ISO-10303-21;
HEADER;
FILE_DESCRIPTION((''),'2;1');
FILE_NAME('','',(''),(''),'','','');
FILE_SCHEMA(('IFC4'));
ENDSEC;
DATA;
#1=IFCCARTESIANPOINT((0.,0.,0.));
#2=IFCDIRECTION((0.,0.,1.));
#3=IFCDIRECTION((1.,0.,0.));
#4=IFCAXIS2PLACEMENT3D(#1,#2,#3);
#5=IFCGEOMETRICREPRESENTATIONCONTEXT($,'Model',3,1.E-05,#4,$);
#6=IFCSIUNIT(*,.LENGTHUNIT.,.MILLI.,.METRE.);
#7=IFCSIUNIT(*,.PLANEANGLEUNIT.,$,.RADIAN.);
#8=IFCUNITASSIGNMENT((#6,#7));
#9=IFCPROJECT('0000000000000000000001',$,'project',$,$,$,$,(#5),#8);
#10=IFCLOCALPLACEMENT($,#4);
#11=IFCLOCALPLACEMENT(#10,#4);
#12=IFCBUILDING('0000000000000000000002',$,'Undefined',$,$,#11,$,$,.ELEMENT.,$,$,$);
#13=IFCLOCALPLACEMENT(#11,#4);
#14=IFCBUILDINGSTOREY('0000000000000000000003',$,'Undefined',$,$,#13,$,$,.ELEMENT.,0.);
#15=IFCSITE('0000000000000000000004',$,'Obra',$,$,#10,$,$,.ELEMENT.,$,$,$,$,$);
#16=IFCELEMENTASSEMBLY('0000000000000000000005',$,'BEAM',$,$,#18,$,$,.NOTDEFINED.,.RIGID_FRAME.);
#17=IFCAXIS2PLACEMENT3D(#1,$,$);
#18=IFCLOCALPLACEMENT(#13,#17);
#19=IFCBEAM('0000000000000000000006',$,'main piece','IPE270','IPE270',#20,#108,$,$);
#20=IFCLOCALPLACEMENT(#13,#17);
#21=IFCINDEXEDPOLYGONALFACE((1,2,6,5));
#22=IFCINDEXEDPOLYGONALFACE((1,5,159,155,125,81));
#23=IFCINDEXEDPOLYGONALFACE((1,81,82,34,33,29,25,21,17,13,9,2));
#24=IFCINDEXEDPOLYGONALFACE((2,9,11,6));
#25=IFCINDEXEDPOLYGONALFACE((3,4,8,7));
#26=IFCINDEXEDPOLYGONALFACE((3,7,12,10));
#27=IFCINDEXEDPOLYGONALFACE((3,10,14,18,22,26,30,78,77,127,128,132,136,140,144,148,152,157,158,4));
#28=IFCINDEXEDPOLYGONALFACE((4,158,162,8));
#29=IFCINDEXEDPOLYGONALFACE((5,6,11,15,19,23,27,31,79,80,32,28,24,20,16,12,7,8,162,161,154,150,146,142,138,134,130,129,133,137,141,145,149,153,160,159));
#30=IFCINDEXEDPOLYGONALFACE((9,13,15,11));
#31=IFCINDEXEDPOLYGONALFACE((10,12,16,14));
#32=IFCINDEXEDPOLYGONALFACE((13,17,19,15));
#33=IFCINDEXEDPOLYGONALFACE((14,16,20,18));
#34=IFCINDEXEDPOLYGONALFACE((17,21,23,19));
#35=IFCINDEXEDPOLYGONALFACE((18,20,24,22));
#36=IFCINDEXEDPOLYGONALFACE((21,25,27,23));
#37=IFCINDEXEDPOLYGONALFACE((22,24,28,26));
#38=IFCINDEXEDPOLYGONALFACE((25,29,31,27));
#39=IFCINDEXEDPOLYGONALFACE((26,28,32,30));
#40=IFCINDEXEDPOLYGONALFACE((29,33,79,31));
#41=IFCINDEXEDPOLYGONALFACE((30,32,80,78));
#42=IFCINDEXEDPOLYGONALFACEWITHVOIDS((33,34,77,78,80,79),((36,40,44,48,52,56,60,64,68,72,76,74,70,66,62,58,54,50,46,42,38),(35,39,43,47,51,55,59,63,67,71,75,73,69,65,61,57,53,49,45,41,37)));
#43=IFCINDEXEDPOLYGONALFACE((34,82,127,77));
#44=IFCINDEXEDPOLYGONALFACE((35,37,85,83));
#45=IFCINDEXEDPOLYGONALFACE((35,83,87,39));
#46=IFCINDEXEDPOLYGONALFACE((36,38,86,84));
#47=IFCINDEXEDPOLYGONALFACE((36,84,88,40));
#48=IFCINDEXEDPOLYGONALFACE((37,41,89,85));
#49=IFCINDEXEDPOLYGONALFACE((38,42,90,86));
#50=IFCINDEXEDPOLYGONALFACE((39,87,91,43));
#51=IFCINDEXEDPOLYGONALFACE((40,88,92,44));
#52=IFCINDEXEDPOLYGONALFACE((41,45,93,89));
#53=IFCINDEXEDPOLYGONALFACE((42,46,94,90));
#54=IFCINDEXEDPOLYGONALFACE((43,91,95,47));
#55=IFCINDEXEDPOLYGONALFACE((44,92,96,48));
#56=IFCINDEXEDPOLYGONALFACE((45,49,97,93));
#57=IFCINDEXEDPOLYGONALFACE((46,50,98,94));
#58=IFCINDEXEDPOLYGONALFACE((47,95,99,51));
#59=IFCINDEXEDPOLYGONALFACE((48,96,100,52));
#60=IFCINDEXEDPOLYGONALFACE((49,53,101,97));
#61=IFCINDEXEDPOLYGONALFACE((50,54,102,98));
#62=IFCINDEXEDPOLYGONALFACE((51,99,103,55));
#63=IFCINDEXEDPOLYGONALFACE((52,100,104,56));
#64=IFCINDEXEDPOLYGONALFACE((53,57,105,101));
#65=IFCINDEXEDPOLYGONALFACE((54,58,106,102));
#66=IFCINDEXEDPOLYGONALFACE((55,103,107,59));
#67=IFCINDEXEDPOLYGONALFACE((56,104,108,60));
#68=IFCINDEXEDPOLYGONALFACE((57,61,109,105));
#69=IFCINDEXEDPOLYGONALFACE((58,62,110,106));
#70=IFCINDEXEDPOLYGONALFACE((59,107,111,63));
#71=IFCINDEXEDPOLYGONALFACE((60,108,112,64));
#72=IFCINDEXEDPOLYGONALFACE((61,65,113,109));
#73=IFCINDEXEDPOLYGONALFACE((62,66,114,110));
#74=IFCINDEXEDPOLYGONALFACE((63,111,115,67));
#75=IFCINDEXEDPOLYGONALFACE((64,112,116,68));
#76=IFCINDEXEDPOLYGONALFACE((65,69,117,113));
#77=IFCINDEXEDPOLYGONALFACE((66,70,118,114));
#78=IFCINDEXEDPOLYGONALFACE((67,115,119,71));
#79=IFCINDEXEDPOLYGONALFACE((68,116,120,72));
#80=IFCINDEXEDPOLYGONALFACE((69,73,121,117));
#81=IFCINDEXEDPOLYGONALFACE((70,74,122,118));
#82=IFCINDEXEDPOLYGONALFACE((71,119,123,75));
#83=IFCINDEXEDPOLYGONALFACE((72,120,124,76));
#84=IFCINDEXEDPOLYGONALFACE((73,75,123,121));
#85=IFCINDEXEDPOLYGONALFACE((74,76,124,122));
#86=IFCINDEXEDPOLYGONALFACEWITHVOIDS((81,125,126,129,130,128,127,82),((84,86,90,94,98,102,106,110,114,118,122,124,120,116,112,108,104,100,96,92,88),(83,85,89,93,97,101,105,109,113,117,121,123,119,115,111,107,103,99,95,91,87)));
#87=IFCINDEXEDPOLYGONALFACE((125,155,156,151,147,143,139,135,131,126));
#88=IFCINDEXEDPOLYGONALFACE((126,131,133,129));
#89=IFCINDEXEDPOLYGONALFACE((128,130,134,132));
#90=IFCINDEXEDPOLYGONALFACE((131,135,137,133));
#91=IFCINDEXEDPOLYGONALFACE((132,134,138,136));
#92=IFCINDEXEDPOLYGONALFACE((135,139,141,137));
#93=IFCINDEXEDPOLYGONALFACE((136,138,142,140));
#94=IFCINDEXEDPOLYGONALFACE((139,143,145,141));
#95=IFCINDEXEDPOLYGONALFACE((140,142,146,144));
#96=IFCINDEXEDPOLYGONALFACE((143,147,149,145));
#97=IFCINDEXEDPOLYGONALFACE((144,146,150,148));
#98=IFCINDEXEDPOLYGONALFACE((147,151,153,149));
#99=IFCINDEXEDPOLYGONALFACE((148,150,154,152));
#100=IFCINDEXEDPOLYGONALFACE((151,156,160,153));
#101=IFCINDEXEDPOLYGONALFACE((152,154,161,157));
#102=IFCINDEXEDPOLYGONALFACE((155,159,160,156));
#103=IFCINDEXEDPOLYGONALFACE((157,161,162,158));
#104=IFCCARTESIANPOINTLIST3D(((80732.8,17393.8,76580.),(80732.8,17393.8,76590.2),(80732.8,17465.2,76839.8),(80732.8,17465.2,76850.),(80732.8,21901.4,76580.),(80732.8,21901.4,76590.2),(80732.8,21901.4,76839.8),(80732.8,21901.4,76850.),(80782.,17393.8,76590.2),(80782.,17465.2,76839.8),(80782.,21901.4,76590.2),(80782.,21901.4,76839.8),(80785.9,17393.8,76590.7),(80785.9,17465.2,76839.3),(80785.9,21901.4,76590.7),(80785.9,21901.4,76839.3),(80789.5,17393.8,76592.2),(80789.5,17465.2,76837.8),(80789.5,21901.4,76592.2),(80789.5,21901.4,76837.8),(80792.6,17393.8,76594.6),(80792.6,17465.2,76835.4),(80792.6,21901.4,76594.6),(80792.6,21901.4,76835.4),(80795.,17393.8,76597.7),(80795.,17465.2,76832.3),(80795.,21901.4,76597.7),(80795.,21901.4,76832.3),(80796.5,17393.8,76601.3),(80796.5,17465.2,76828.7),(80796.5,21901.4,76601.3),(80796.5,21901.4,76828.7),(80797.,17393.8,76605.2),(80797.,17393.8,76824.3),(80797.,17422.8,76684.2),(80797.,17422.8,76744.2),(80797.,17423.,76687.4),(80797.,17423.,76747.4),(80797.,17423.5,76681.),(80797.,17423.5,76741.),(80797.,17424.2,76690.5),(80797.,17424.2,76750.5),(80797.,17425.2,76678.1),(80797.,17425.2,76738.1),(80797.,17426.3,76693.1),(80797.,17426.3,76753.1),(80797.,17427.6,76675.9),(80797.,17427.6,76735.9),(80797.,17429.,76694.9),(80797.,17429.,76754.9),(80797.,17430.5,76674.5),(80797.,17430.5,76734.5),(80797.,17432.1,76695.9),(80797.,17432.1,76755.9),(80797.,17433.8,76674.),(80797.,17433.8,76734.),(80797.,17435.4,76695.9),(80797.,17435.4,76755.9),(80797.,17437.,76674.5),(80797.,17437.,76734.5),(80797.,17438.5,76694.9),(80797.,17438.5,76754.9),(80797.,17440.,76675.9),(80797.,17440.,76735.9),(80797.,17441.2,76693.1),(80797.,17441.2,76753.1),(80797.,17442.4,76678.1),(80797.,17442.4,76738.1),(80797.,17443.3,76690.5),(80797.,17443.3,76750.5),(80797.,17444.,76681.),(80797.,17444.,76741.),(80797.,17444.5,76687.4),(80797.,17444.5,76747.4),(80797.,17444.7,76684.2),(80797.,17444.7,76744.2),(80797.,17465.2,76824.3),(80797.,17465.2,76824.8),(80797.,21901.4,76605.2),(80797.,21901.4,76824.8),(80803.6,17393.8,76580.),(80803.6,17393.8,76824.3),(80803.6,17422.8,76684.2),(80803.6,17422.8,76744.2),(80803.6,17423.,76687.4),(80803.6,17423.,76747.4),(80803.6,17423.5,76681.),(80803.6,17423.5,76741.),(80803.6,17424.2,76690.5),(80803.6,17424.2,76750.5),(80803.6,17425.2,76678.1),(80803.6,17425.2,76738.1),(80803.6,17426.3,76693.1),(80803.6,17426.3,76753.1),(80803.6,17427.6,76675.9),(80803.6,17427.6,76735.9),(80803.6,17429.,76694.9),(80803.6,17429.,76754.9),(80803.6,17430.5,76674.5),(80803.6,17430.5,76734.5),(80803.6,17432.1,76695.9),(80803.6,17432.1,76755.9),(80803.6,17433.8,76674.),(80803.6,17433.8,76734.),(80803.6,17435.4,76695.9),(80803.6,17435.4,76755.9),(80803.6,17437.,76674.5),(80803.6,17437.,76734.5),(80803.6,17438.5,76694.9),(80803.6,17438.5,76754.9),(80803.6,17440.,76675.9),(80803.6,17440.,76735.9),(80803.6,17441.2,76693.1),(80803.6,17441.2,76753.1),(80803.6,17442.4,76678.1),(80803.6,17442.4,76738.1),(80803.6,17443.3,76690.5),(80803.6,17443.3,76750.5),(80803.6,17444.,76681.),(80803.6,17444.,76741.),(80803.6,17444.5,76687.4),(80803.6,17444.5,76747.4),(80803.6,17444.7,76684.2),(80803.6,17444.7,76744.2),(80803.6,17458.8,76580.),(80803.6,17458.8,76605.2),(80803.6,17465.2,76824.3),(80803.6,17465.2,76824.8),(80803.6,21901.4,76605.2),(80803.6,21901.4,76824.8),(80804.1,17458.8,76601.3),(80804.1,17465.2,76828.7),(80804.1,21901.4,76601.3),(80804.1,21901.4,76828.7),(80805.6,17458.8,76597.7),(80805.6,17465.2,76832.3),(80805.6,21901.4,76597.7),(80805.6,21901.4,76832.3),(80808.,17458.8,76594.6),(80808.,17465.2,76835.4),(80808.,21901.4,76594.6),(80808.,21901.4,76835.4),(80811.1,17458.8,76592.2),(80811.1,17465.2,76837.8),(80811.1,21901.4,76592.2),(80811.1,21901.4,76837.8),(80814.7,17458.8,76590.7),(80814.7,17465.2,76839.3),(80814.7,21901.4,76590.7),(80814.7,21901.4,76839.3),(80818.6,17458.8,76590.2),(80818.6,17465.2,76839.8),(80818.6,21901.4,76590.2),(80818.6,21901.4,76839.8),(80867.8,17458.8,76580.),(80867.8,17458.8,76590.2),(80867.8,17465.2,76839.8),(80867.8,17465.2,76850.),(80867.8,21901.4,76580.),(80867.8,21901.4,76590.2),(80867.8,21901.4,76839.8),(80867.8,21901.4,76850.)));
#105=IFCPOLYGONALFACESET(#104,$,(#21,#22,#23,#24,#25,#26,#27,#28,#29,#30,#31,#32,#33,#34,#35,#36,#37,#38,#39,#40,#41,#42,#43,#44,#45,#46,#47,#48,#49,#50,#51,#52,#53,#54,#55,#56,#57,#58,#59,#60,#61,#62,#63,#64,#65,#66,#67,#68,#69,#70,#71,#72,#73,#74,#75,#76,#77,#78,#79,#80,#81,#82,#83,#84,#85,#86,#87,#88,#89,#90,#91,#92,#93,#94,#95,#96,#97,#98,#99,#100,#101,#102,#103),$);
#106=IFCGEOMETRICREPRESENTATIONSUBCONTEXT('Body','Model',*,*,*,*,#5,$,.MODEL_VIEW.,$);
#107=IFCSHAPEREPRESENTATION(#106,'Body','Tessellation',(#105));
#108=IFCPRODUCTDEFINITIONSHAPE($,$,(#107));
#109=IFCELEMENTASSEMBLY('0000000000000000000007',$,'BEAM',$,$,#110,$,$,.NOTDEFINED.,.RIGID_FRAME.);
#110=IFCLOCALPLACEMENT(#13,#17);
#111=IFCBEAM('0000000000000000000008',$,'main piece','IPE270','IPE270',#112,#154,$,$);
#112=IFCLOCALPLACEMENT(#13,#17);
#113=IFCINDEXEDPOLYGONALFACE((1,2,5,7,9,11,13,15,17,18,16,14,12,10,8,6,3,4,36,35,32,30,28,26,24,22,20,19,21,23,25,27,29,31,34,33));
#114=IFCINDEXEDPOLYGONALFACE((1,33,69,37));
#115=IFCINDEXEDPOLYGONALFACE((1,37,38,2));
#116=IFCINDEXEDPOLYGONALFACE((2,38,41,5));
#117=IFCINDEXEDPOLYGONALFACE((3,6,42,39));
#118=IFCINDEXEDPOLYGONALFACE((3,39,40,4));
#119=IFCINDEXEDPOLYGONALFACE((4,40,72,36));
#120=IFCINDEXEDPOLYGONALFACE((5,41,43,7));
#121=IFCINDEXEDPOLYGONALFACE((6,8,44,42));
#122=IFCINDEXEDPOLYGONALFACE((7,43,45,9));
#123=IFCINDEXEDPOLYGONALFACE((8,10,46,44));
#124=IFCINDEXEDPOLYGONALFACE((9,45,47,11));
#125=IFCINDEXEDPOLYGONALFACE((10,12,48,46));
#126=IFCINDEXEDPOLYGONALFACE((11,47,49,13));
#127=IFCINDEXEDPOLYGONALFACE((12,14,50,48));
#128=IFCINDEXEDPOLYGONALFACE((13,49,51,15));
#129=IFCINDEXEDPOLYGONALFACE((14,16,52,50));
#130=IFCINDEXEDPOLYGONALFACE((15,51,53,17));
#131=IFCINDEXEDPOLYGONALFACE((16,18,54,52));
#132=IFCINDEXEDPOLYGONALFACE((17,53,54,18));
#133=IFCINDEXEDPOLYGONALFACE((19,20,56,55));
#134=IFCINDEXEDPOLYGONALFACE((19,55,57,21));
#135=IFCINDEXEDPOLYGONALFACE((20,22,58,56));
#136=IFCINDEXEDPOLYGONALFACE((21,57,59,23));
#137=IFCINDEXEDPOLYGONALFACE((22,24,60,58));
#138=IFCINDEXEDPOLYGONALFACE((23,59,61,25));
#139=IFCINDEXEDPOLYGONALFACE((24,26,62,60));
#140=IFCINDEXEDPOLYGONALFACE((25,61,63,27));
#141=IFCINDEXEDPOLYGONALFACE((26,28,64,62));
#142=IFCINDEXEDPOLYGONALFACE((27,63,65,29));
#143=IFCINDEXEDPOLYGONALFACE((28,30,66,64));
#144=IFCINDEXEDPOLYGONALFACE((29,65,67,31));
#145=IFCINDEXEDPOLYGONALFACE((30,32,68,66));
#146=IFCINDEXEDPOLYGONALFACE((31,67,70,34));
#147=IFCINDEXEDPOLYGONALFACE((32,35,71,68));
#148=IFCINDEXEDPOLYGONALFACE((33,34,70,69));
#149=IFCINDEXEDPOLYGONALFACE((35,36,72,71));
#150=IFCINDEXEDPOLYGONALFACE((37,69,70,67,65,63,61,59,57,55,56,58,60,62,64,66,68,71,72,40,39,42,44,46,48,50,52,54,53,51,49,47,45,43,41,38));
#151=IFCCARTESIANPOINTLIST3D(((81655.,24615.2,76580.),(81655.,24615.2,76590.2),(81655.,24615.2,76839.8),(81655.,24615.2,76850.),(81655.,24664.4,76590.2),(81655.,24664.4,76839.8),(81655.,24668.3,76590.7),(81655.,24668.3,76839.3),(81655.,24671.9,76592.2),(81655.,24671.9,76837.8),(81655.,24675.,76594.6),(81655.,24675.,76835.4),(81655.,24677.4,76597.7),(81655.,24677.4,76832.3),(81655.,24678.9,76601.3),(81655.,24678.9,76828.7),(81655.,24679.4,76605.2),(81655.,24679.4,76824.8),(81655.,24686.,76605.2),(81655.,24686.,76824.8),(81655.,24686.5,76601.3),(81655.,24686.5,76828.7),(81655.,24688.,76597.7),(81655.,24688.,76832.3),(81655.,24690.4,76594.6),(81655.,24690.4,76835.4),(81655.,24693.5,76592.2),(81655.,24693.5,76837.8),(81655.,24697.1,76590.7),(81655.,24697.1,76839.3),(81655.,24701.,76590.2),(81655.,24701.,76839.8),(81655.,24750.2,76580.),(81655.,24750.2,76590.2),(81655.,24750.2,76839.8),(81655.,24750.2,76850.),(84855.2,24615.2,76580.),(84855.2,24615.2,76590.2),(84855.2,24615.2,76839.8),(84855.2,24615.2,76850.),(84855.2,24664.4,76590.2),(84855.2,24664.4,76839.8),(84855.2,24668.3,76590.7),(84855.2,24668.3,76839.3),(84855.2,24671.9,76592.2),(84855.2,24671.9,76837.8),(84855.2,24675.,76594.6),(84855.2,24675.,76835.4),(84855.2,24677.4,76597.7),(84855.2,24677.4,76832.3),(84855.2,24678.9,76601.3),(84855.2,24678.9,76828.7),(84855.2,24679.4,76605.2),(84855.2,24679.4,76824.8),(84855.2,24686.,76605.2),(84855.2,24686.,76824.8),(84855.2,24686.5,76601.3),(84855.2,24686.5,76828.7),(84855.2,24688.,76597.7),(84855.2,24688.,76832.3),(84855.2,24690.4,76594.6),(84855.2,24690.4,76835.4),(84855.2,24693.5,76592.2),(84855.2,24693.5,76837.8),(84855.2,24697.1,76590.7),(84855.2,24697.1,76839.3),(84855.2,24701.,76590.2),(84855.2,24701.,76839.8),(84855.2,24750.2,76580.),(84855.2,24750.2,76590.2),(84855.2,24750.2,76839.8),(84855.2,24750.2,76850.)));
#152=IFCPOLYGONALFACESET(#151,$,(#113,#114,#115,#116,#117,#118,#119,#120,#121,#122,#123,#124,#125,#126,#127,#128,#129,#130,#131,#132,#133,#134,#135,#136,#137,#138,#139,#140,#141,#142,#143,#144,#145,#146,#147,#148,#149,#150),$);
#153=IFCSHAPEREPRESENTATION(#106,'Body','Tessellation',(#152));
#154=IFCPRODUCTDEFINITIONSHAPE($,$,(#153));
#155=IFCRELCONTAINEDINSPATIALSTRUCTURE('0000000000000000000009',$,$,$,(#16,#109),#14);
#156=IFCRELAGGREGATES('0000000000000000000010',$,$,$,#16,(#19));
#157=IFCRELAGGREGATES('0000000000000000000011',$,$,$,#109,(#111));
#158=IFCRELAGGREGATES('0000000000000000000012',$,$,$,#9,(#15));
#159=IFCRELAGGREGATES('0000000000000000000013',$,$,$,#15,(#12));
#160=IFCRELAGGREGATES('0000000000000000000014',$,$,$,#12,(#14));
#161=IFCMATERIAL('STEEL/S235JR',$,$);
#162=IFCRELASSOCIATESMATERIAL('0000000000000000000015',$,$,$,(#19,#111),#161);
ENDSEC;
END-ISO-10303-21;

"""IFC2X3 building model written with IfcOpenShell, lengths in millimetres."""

from ifc_helpers import new_model, si_unit, frame, origin_with_axes, origin_2d_with_axis, place, context, subcontext, project, spatial, rectangle, circle, i_section, extrude, clip, halfspace, source, transform, mapped, material, element, aggregate, save


model = new_model("IFC2X3")

# Units and contexts
model_context = context("Model", 3, precision=1e-05, world=origin_with_axes())
body_context = subcontext(model_context, "Body", "Model", "MODEL_VIEW")
ifc_project = project(units=[si_unit("LENGTHUNIT", "METRE", prefix="MILLI"), si_unit("PLANEANGLEUNIT", "RADIAN")], contexts=[model_context])

# Site, building, storey
site_placement = place(None, origin_with_axes())
site = spatial("IfcSite", under=ifc_project, at=site_placement, Name="Obra", CompositionType="ELEMENT")
building_placement = place(site_placement, origin_with_axes())
building = spatial("IfcBuilding", under=site, at=building_placement, Name="Undefined", CompositionType="ELEMENT")
storey_placement = place(building_placement, origin_with_axes())
storey = spatial("IfcBuildingStorey", under=building, at=storey_placement, Name="Undefined", CompositionType="ELEMENT", Elevation=0.0)

# Shared definitions
ifc_material = material(Name="STEEL/S235JR")

# Element assembly, beam, openings
shared_shape = source(origin_with_axes(), body_context, "Body", "SweptSolid", [
    extrude(circle(Radius=11.0, at=origin_2d_with_axis()), frame((0.0, -3.4, 0.0), z_axis=(0.0, 1.0, 0.0), x_axis=(1.0, 0.0, 0.0)), (0.0, 0.0, 1.0), 6.8),
])
assembly_1_placement = place(storey_placement, origin_with_axes())
assembly_1 = element("IfcElementAssembly", 1, at=assembly_1_placement, inside=storey, Name="BEAM", AssemblyPlace="NOTDEFINED", PredefinedType="RIGID_FRAME")
beam_1_placement = place(assembly_1_placement, frame((80800.3, 17475.2, 76715.0), z_axis=(0.0, 0.0, 1.0), x_axis=(0.0, 1.0, 0.0)))
beam_1 = element("IfcBeam", 2, at=beam_1_placement, material=ifc_material, Name="main piece", Description="IPE270", ObjectType="IPE270", context=body_context, shape_type="Clipping", body=[
    clip(extrude(i_section(OverallWidth=135.0, OverallDepth=270.0, WebThickness=6.6, FlangeThickness=10.2, FilletRadius=15.0, at=origin_2d_with_axis()), frame((4426.2, 0.0, 0.0), z_axis=(-1.0, 0.0, 0.0), x_axis=(0.0, -1.0, 0.0)), (0.0, 0.0, 1.0), 4507.6), halfspace(frame((-81.4, 0.0, -235.0), z_axis=(1.0, 0.0, 0.0), x_axis=(0.0, -1.0, 0.0)), True)),
])
opening_1_placement = place(assembly_1_placement, frame((80800.3, 17475.2, 76715.0), z_axis=(0.0, 0.0, 1.0), x_axis=(0.0, 1.0, 0.0)))
element("IfcOpeningElement", 3, at=opening_1_placement, cuts=beam_1, ObjectType="Recess", context=body_context, shape_type="SweptSolid", body=[
    extrude(rectangle(XDim=75.0, YDim=300.0, at=origin_2d_with_axis()), frame((-53.9, -153.3, 124.3), z_axis=(0.0, 0.0, -1.0), x_axis=(1.0, 0.0, 0.0)), (0.0, 0.0, 1.0), 278.6),
])
opening_2_placement = place(assembly_1_placement, frame((80800.3, 17475.2, 76715.0), z_axis=(0.0, 0.0, 1.0), x_axis=(0.0, 1.0, 0.0)))
element("IfcOpeningElement", 4, at=opening_2_placement, cuts=beam_1, ObjectType="Recess", context=body_context, shape_type="SweptSolid", body=[
    extrude(rectangle(XDim=26.7, YDim=83.5, at=origin_2d_with_axis()), frame((-51.7, -68.5, 122.7), z_axis=(0.0, 1.0, 0.0), x_axis=(0.0, 0.0, -1.0)), (0.0, 0.0, 1.0), 137.0),
])
opening_3_placement = place(assembly_1_placement, frame((80800.3, 17393.8, 76850.0), z_axis=(0.0, 1.0, 0.0), x_axis=(0.0, 0.0, -1.0)))
element("IfcOpeningElement", 5, at=opening_3_placement, cuts=beam_1, ObjectType="Opening", context=body_context, shape_type="MappedRepresentation", body=[
    mapped(shared_shape, transform((105.0, 0.0, 40.0))),
    mapped(shared_shape, transform((165.0, 0.0, 40.0))),
])
aggregate(assembly_1, [beam_1])

# Element assembly, beam
assembly_2_placement = place(storey_placement, origin_with_axes())
assembly_2 = element("IfcElementAssembly", 6, at=assembly_2_placement, inside=storey, Name="BEAM", AssemblyPlace="NOTDEFINED", PredefinedType="RIGID_FRAME")
beam_2_placement = place(assembly_2_placement, frame((81655.0, 24682.7, 76715.0), z_axis=(0.0, 0.0, 1.0), x_axis=(1.0, 0.000002, 0.0)))
beam_2 = element("IfcBeam", 7, at=beam_2_placement, material=ifc_material, Name="main piece", Description="IPE270", ObjectType="IPE270", context=body_context, shape_type="SweptSolid", body=[
    extrude(i_section(OverallWidth=135.0, OverallDepth=270.0, WebThickness=6.6, FlangeThickness=10.2, FilletRadius=15.0, at=origin_2d_with_axis()), frame((3200.1, 0.0, 0.0), z_axis=(-1.0, 0.0, 0.0), x_axis=(0.0, -1.0, 0.0)), (0.0, 0.0, 1.0), 3200.1),
])
aggregate(assembly_2, [beam_2])

save(model, "model.ifc")
